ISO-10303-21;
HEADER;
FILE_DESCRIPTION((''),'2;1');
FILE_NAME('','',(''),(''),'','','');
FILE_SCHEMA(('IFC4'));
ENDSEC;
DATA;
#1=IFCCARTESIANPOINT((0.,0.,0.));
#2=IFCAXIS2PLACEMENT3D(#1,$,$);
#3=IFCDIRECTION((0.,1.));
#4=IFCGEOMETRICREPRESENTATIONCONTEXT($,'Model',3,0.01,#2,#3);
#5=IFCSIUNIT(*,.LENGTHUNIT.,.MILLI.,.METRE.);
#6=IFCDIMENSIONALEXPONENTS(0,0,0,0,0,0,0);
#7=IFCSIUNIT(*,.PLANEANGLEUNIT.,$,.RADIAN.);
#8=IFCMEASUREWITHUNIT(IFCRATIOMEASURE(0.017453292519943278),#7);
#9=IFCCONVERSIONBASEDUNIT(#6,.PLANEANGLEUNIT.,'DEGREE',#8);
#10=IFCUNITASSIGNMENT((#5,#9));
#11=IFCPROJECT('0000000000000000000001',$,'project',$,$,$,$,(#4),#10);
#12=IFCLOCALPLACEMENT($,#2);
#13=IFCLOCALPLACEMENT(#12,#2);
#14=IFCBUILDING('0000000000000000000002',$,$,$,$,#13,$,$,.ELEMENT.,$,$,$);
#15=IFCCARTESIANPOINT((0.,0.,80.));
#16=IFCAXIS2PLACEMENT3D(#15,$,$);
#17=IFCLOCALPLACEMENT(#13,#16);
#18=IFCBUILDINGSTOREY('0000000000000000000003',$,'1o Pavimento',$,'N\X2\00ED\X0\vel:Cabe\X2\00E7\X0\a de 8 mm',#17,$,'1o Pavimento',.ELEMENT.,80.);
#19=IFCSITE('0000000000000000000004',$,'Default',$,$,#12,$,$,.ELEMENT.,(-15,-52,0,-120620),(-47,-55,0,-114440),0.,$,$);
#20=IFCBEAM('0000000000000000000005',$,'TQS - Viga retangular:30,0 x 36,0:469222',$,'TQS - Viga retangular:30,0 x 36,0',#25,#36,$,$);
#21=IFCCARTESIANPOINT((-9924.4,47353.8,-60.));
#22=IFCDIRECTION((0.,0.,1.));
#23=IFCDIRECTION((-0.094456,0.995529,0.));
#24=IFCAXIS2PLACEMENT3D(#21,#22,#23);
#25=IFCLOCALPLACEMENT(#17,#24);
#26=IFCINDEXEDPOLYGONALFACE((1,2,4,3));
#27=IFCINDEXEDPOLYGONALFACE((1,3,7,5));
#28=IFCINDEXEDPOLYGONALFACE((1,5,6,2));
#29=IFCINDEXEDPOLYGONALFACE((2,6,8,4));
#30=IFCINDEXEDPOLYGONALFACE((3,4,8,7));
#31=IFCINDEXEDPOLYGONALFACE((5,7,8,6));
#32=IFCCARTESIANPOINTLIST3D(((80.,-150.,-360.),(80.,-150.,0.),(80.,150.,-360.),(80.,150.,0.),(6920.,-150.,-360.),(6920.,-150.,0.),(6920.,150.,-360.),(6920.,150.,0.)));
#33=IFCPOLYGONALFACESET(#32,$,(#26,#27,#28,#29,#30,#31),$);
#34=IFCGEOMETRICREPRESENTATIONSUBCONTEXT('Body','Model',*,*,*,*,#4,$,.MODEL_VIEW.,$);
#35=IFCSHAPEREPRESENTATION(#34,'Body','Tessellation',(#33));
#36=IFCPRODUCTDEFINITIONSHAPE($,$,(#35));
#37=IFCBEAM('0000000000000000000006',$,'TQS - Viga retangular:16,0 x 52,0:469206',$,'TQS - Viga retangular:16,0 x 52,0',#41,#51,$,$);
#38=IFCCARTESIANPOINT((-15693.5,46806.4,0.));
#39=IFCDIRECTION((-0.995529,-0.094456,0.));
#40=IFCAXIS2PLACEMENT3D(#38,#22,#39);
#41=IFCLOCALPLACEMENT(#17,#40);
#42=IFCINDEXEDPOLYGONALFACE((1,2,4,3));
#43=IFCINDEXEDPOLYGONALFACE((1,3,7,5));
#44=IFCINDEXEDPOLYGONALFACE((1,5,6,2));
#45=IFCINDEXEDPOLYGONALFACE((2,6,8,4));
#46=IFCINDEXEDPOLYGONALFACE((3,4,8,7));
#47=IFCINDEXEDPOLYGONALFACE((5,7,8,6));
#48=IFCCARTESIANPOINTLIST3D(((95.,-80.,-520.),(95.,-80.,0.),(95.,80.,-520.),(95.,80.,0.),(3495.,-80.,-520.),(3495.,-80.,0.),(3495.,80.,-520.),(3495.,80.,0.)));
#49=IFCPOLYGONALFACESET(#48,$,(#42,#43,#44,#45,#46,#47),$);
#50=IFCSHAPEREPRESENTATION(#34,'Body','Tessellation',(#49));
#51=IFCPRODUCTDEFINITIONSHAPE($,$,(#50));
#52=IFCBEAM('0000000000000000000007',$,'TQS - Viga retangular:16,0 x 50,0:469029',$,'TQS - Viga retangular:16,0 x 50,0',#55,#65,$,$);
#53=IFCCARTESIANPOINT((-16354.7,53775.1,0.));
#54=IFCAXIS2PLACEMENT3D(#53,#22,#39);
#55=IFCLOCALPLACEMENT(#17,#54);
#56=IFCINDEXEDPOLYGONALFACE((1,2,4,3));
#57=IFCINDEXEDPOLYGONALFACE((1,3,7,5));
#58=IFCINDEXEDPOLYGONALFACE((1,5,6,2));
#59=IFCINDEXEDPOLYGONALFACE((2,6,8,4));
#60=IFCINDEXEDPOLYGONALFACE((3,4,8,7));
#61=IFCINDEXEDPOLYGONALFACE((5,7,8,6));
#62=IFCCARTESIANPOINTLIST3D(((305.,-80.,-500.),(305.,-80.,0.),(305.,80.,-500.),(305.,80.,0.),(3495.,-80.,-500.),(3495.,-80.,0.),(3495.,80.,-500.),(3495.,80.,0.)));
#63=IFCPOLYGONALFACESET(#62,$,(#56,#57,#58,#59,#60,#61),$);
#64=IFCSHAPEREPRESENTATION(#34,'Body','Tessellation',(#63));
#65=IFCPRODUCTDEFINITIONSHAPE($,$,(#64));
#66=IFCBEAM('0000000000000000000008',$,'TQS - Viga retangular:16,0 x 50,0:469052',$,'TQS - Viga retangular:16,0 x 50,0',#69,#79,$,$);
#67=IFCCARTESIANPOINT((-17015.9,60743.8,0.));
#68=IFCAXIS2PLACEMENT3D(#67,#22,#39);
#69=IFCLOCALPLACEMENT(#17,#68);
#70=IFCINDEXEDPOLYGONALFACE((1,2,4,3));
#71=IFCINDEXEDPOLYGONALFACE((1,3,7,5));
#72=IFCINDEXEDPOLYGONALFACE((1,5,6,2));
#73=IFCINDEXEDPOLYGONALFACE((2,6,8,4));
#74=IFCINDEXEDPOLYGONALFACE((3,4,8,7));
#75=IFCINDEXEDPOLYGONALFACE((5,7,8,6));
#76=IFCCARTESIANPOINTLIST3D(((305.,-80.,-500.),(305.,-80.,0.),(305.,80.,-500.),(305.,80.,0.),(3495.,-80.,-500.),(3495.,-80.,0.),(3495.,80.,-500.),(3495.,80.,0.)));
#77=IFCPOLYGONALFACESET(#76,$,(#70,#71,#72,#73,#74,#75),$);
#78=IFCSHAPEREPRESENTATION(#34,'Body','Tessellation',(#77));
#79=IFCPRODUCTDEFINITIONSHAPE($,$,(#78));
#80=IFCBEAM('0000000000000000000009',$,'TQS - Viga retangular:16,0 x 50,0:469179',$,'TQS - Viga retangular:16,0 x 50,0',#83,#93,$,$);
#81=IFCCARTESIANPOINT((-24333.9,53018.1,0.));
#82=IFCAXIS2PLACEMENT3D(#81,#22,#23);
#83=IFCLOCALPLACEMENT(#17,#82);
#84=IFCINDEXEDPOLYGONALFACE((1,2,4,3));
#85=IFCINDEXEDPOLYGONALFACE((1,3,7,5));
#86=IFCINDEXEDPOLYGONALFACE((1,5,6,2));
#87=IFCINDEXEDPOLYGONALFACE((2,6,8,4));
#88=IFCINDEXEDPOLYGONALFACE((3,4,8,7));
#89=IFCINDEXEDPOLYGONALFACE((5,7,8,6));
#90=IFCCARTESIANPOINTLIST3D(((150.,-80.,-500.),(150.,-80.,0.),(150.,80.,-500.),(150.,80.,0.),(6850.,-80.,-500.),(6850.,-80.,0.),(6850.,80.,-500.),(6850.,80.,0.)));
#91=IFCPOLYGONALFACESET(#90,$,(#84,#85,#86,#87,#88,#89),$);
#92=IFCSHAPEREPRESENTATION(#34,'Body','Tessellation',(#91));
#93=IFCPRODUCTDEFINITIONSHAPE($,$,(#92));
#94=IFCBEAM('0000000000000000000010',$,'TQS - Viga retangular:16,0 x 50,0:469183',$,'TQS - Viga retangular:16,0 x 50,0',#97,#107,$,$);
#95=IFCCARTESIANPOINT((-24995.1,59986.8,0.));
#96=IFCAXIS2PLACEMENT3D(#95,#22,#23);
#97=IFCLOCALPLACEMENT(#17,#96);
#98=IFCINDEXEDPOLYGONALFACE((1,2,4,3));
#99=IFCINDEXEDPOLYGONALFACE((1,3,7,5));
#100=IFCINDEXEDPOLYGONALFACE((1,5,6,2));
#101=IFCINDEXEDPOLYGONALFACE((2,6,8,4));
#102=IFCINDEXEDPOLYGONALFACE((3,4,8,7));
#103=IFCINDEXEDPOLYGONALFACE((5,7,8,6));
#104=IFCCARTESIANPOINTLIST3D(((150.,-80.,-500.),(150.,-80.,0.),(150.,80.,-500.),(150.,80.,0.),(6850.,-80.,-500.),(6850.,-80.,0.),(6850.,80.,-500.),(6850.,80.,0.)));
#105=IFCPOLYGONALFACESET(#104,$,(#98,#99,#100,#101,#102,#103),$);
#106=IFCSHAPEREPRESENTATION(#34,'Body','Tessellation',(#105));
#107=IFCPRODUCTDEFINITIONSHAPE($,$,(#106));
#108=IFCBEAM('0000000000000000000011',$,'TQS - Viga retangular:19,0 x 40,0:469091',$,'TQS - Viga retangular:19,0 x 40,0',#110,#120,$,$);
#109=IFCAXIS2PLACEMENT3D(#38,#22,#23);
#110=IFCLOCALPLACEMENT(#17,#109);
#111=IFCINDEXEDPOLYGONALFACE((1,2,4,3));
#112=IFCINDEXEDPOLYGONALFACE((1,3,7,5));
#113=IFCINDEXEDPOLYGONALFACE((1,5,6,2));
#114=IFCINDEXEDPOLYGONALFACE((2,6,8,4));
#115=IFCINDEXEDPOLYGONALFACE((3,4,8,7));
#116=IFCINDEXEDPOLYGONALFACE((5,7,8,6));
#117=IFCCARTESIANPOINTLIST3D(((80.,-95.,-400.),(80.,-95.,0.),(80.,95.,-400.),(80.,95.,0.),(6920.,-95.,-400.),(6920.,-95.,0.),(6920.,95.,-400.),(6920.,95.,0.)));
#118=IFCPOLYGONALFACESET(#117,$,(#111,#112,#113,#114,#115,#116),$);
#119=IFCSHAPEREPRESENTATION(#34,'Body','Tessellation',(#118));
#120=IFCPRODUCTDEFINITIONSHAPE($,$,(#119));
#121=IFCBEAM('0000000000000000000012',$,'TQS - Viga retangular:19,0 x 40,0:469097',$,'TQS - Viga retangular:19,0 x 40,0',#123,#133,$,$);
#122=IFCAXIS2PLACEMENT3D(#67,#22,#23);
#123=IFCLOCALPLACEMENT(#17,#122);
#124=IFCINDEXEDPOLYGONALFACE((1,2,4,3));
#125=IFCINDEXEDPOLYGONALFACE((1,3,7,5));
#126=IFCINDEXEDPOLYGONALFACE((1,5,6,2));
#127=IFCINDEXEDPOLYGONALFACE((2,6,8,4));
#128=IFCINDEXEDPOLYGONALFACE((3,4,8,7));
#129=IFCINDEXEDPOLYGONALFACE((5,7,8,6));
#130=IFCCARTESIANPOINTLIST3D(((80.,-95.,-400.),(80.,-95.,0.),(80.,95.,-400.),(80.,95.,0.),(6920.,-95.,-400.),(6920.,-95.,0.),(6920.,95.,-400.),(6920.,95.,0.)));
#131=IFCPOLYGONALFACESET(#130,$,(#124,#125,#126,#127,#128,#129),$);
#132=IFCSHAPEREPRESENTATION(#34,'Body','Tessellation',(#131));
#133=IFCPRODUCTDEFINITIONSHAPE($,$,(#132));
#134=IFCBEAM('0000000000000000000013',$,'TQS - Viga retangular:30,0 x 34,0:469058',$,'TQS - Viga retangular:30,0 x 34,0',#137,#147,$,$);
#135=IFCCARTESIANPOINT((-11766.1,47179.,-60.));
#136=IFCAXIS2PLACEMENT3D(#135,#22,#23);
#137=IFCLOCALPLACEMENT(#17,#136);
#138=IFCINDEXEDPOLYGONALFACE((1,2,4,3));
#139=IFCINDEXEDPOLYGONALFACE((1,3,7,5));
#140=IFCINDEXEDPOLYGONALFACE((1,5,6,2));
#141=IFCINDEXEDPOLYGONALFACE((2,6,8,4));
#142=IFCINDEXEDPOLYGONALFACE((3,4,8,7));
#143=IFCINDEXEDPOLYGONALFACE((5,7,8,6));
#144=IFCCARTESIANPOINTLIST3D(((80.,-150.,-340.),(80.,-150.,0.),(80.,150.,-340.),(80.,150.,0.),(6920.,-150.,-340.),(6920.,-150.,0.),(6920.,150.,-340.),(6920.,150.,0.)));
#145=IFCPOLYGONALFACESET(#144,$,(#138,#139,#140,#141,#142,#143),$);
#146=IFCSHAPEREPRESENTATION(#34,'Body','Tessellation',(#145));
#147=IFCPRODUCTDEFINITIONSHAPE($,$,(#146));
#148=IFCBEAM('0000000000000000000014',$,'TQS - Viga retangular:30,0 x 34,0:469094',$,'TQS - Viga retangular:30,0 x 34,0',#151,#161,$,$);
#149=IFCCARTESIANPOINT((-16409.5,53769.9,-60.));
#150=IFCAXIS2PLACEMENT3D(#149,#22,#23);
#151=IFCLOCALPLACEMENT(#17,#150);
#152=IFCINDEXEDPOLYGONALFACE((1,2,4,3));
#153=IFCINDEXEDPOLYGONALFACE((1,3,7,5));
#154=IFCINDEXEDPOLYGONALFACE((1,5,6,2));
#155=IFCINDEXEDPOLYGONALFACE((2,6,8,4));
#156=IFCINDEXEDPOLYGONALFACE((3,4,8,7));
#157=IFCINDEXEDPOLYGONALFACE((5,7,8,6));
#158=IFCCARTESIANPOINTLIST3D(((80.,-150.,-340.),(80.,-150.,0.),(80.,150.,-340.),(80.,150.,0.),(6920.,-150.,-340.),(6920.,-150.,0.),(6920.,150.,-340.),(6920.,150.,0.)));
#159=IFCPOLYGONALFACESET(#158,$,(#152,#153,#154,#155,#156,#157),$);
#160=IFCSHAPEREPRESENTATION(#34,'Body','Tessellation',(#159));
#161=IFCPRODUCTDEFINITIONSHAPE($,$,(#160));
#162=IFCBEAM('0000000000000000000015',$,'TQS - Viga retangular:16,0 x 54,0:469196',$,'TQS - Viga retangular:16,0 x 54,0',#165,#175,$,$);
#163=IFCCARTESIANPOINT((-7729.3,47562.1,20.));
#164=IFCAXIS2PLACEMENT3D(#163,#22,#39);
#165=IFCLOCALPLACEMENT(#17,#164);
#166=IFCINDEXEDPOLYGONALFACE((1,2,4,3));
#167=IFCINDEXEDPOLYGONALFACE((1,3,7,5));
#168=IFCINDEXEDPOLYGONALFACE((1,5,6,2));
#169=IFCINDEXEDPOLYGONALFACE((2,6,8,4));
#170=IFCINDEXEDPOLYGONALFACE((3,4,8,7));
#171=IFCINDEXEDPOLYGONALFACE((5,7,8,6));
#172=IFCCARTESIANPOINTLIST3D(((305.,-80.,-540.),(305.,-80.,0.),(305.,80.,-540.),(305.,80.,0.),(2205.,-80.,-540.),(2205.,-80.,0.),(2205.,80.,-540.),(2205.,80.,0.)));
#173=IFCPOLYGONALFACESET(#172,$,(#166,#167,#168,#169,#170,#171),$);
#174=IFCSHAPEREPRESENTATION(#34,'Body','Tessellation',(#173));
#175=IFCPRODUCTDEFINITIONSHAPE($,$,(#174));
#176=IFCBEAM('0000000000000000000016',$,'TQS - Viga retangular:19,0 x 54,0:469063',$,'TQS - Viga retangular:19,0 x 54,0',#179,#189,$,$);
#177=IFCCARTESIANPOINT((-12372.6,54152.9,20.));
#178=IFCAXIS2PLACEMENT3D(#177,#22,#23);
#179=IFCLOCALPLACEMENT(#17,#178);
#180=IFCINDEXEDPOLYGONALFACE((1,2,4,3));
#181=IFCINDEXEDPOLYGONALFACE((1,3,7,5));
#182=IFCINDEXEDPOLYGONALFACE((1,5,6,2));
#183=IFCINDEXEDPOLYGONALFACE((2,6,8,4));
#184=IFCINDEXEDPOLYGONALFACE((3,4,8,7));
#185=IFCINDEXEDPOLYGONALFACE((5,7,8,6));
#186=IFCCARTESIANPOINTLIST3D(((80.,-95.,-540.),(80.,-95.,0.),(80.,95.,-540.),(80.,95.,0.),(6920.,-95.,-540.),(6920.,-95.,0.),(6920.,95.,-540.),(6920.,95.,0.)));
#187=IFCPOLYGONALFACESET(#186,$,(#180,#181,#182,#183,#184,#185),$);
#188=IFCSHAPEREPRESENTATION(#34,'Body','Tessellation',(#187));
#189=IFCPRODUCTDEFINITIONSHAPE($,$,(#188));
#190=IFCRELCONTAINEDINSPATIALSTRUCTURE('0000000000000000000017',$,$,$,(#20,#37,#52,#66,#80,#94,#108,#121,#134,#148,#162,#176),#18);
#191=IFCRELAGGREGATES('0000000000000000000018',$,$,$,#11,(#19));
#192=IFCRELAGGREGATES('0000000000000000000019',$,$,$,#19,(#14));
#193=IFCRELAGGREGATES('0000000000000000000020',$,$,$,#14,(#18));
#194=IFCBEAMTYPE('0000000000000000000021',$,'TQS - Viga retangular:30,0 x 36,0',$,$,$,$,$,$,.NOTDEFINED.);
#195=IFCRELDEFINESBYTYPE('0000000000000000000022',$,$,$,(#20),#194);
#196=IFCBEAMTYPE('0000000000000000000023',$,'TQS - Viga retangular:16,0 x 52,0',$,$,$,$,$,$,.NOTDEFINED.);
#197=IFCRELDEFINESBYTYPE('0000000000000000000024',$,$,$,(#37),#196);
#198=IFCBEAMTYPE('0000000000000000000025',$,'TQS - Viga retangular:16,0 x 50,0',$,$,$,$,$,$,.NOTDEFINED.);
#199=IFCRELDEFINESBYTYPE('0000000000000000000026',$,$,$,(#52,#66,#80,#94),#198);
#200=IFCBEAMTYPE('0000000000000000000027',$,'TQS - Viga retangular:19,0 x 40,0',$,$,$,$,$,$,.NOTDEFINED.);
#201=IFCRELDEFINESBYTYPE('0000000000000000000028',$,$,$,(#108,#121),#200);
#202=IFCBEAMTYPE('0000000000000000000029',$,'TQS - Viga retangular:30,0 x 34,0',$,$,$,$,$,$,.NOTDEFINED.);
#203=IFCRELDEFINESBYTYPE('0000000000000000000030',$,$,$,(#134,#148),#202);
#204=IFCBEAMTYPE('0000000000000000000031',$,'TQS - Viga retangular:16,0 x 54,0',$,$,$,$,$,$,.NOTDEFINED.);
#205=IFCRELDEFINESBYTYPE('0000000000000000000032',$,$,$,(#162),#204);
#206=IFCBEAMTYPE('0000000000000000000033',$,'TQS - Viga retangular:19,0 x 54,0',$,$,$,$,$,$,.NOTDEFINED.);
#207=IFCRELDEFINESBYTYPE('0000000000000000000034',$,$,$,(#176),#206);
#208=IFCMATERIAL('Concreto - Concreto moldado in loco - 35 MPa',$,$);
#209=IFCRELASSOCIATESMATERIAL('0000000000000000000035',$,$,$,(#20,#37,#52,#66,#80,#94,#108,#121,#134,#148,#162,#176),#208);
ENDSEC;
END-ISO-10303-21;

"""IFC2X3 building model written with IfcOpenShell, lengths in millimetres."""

from ifc_helpers import new_model, entity, si_unit, converted_unit, direction, frame, frame_2d, origin, origin_2d_with_axis, place, context, subcontext, project, spatial, rectangle, extrude, material, type_object, element, save


model = new_model("IFC2X3")

# Units and contexts
model_context = context("Model", 3, precision=0.01, world=origin(), true_north=direction((0.0, 1.0)))
body_context = subcontext(model_context, "Body", "Model", "MODEL_VIEW")
ifc_project = project(units=[si_unit("LENGTHUNIT", "METRE", prefix="MILLI"), converted_unit("PLANEANGLEUNIT", "DEGREE", entity("IfcRatioMeasure", 0.017453292519943278), si_unit("PLANEANGLEUNIT", "RADIAN"), dimensions=[0, 0, 0, 0, 0, 0, 0])], contexts=[model_context])

# Site, building, storey
site_placement = place(None, origin())
site = spatial("IfcSite", under=ifc_project, at=site_placement, Name="Default", CompositionType="ELEMENT", RefLatitude=(-15, -52, 0, -120620), RefLongitude=(-47, -55, 0, -114440), RefElevation=0.0)
building_placement = place(site_placement, origin())
building = spatial("IfcBuilding", under=site, at=building_placement, CompositionType="ELEMENT")
storey_placement = place(building_placement, frame((0.0, 0.0, 80.0)))
storey = spatial("IfcBuildingStorey", under=building, at=storey_placement, Name="1o Pavimento", ObjectType="Nível:Cabeça de 8 mm", LongName="1o Pavimento", CompositionType="ELEMENT", Elevation=80.0)

# Beams
ifc_material_1 = material(Name="Concreto - Concreto moldado in loco - 35 MPa")
beam_type_1 = type_object("IfcBeamType", Name="TQS - Viga retangular:30,0 x 36,0", PredefinedType="NOTDEFINED")
beam_1_placement = place(storey_placement, frame((-9924.4, 47353.8, -60.0), z_axis=(0.0, 0.0, 1.0), x_axis=(-0.094456, 0.995529, 0.0)))
element("IfcBeam", 1, at=beam_1_placement, inside=storey, type_object=beam_type_1, material=ifc_material_1, Name="TQS - Viga retangular:30,0 x 36,0:469222", ObjectType="TQS - Viga retangular:30,0 x 36,0", context=body_context, shape_type="SweptSolid", body=[
    extrude(rectangle(XDim=360.0, YDim=300.0, at=origin_2d_with_axis()), frame((80.0, 0.0, -180.0), z_axis=(1.0, 0.0, 0.0), x_axis=(0.0, 0.0, -1.0)), (0.0, 0.0, 1.0), 6840.0),
])
beam_type_2 = type_object("IfcBeamType", Name="TQS - Viga retangular:16,0 x 52,0", PredefinedType="NOTDEFINED")
beam_2_placement = place(storey_placement, frame((-15693.5, 46806.4, 0.0), z_axis=(0.0, 0.0, 1.0), x_axis=(-0.995529, -0.094456, 0.0)))
element("IfcBeam", 2, at=beam_2_placement, inside=storey, type_object=beam_type_2, material=ifc_material_1, Name="TQS - Viga retangular:16,0 x 52,0:469206", ObjectType="TQS - Viga retangular:16,0 x 52,0", context=body_context, shape_type="SweptSolid", body=[
    extrude(rectangle(XDim=520.0, YDim=160.0, at=frame_2d((0.0, 0.0), x_axis=(1.0, 0.0))), frame((95.0, 0.0, -260.0), z_axis=(1.0, 0.0, 0.0), x_axis=(0.0, 0.0, -1.0)), (0.0, 0.0, 1.0), 3400.0),
])
beam_type_3 = type_object("IfcBeamType", Name="TQS - Viga retangular:16,0 x 50,0", PredefinedType="NOTDEFINED")
beam_3_placement = place(storey_placement, frame((-16354.7, 53775.1, 0.0), z_axis=(0.0, 0.0, 1.0), x_axis=(-0.995529, -0.094456, 0.0)))
element("IfcBeam", 3, at=beam_3_placement, inside=storey, type_object=beam_type_3, material=ifc_material_1, Name="TQS - Viga retangular:16,0 x 50,0:469029", ObjectType="TQS - Viga retangular:16,0 x 50,0", context=body_context, shape_type="SweptSolid", body=[
    extrude(rectangle(XDim=500.0, YDim=160.0, at=frame_2d((0.0, 0.0), x_axis=(1.0, 0.0))), frame((305.0, 0.0, -250.0), z_axis=(1.0, 0.0, 0.0), x_axis=(0.0, 0.0, -1.0)), (0.0, 0.0, 1.0), 3190.0),
])
beam_4_placement = place(storey_placement, frame((-17015.9, 60743.8, 0.0), z_axis=(0.0, 0.0, 1.0), x_axis=(-0.995529, -0.094456, 0.0)))
element("IfcBeam", 4, at=beam_4_placement, inside=storey, type_object=beam_type_3, material=ifc_material_1, Name="TQS - Viga retangular:16,0 x 50,0:469052", ObjectType="TQS - Viga retangular:16,0 x 50,0", context=body_context, shape_type="SweptSolid", body=[
    extrude(rectangle(XDim=500.0, YDim=160.0, at=frame_2d((0.0, 0.0), x_axis=(1.0, 0.0))), frame((305.0, 0.0, -250.0), z_axis=(1.0, 0.0, 0.0), x_axis=(0.0, 0.0, -1.0)), (0.0, 0.0, 1.0), 3190.0),
])
beam_5_placement = place(storey_placement, frame((-24333.9, 53018.1, 0.0), z_axis=(0.0, 0.0, 1.0), x_axis=(-0.094456, 0.995529, 0.0)))
element("IfcBeam", 5, at=beam_5_placement, inside=storey, type_object=beam_type_3, material=ifc_material_1, Name="TQS - Viga retangular:16,0 x 50,0:469179", ObjectType="TQS - Viga retangular:16,0 x 50,0", context=body_context, shape_type="SweptSolid", body=[
    extrude(rectangle(XDim=500.0, YDim=160.0, at=frame_2d((0.0, 0.0), x_axis=(1.0, 0.0))), frame((150.0, 0.0, -250.0), z_axis=(1.0, 0.0, 0.0), x_axis=(0.0, 0.0, -1.0)), (0.0, 0.0, 1.0), 6700.0),
])
beam_6_placement = place(storey_placement, frame((-24995.1, 59986.8, 0.0), z_axis=(0.0, 0.0, 1.0), x_axis=(-0.094456, 0.995529, 0.0)))
element("IfcBeam", 6, at=beam_6_placement, inside=storey, type_object=beam_type_3, material=ifc_material_1, Name="TQS - Viga retangular:16,0 x 50,0:469183", ObjectType="TQS - Viga retangular:16,0 x 50,0", context=body_context, shape_type="SweptSolid", body=[
    extrude(rectangle(XDim=500.0, YDim=160.0, at=frame_2d((0.0, 0.0), x_axis=(1.0, 0.0))), frame((150.0, 0.0, -250.0), z_axis=(1.0, 0.0, 0.0), x_axis=(0.0, 0.0, -1.0)), (0.0, 0.0, 1.0), 6700.0),
])
beam_type_4 = type_object("IfcBeamType", Name="TQS - Viga retangular:19,0 x 40,0", PredefinedType="NOTDEFINED")
beam_7_placement = place(storey_placement, frame((-15693.5, 46806.4, 0.0), z_axis=(0.0, 0.0, 1.0), x_axis=(-0.094456, 0.995529, 0.0)))
element("IfcBeam", 7, at=beam_7_placement, inside=storey, type_object=beam_type_4, material=ifc_material_1, Name="TQS - Viga retangular:19,0 x 40,0:469091", ObjectType="TQS - Viga retangular:19,0 x 40,0", context=body_context, shape_type="SweptSolid", body=[
    extrude(rectangle(XDim=400.0, YDim=190.0, at=frame_2d((0.0, 0.0), x_axis=(1.0, 0.0))), frame((80.0, 0.0, -200.0), z_axis=(1.0, 0.0, 0.0), x_axis=(0.0, 0.0, -1.0)), (0.0, 0.0, 1.0), 6840.0),
])
beam_8_placement = place(storey_placement, frame((-17015.9, 60743.8, 0.0), z_axis=(0.0, 0.0, 1.0), x_axis=(-0.094456, 0.995529, 0.0)))
element("IfcBeam", 8, at=beam_8_placement, inside=storey, type_object=beam_type_4, material=ifc_material_1, Name="TQS - Viga retangular:19,0 x 40,0:469097", ObjectType="TQS - Viga retangular:19,0 x 40,0", context=body_context, shape_type="SweptSolid", body=[
    extrude(rectangle(XDim=400.0, YDim=190.0, at=frame_2d((0.0, 0.0), x_axis=(1.0, 0.0))), frame((80.0, 0.0, -200.0), z_axis=(1.0, 0.0, 0.0), x_axis=(0.0, 0.0, -1.0)), (0.0, 0.0, 1.0), 6840.0),
])
beam_type_5 = type_object("IfcBeamType", Name="TQS - Viga retangular:30,0 x 34,0", PredefinedType="NOTDEFINED")
beam_9_placement = place(storey_placement, frame((-11766.1, 47179.0, -60.0), z_axis=(0.0, 0.0, 1.0), x_axis=(-0.094456, 0.995529, 0.0)))
element("IfcBeam", 9, at=beam_9_placement, inside=storey, type_object=beam_type_5, material=ifc_material_1, Name="TQS - Viga retangular:30,0 x 34,0:469058", ObjectType="TQS - Viga retangular:30,0 x 34,0", context=body_context, shape_type="SweptSolid", body=[
    extrude(rectangle(XDim=340.0, YDim=300.0, at=frame_2d((0.0, 0.0), x_axis=(1.0, 0.0))), frame((80.0, 0.0, -170.0), z_axis=(1.0, 0.0, 0.0), x_axis=(0.0, 0.0, -1.0)), (0.0, 0.0, 1.0), 6840.0),
])
beam_10_placement = place(storey_placement, frame((-16409.5, 53769.9, -60.0), z_axis=(0.0, 0.0, 1.0), x_axis=(-0.094456, 0.995529, 0.0)))
element("IfcBeam", 10, at=beam_10_placement, inside=storey, type_object=beam_type_5, material=ifc_material_1, Name="TQS - Viga retangular:30,0 x 34,0:469094", ObjectType="TQS - Viga retangular:30,0 x 34,0", context=body_context, shape_type="SweptSolid", body=[
    extrude(rectangle(XDim=340.0, YDim=300.0, at=frame_2d((0.0, 0.0), x_axis=(1.0, 0.0))), frame((80.0, 0.0, -170.0), z_axis=(1.0, 0.0, 0.0), x_axis=(0.0, 0.0, -1.0)), (0.0, 0.0, 1.0), 6840.0),
])
beam_type_6 = type_object("IfcBeamType", Name="TQS - Viga retangular:16,0 x 54,0", PredefinedType="NOTDEFINED")
beam_11_placement = place(storey_placement, frame((-7729.3, 47562.1, 20.0), z_axis=(0.0, 0.0, 1.0), x_axis=(-0.995529, -0.094456, 0.0)))
element("IfcBeam", 11, at=beam_11_placement, inside=storey, type_object=beam_type_6, material=ifc_material_1, Name="TQS - Viga retangular:16,0 x 54,0:469196", ObjectType="TQS - Viga retangular:16,0 x 54,0", context=body_context, shape_type="SweptSolid", body=[
    extrude(rectangle(XDim=540.0, YDim=160.0, at=origin_2d_with_axis()), frame((305.0, 0.0, -270.0), z_axis=(1.0, 0.0, 0.0), x_axis=(0.0, 0.0, -1.0)), (0.0, 0.0, 1.0), 1900.0),
])
beam_type_7 = type_object("IfcBeamType", Name="TQS - Viga retangular:19,0 x 54,0", PredefinedType="NOTDEFINED")
beam_12_placement = place(storey_placement, frame((-12372.6, 54152.9, 20.0), z_axis=(0.0, 0.0, 1.0), x_axis=(-0.094456, 0.995529, 0.0)))
element("IfcBeam", 12, at=beam_12_placement, inside=storey, type_object=beam_type_7, material=ifc_material_1, Name="TQS - Viga retangular:19,0 x 54,0:469063", ObjectType="TQS - Viga retangular:19,0 x 54,0", context=body_context, shape_type="SweptSolid", body=[
    extrude(rectangle(XDim=540.0, YDim=190.0, at=frame_2d((0.0, 0.0), x_axis=(1.0, 0.0))), frame((80.0, 0.0, -270.0), z_axis=(1.0, 0.0, 0.0), x_axis=(0.0, 0.0, -1.0)), (0.0, 0.0, 1.0), 6840.0),
])

save(model, "model.ifc")
